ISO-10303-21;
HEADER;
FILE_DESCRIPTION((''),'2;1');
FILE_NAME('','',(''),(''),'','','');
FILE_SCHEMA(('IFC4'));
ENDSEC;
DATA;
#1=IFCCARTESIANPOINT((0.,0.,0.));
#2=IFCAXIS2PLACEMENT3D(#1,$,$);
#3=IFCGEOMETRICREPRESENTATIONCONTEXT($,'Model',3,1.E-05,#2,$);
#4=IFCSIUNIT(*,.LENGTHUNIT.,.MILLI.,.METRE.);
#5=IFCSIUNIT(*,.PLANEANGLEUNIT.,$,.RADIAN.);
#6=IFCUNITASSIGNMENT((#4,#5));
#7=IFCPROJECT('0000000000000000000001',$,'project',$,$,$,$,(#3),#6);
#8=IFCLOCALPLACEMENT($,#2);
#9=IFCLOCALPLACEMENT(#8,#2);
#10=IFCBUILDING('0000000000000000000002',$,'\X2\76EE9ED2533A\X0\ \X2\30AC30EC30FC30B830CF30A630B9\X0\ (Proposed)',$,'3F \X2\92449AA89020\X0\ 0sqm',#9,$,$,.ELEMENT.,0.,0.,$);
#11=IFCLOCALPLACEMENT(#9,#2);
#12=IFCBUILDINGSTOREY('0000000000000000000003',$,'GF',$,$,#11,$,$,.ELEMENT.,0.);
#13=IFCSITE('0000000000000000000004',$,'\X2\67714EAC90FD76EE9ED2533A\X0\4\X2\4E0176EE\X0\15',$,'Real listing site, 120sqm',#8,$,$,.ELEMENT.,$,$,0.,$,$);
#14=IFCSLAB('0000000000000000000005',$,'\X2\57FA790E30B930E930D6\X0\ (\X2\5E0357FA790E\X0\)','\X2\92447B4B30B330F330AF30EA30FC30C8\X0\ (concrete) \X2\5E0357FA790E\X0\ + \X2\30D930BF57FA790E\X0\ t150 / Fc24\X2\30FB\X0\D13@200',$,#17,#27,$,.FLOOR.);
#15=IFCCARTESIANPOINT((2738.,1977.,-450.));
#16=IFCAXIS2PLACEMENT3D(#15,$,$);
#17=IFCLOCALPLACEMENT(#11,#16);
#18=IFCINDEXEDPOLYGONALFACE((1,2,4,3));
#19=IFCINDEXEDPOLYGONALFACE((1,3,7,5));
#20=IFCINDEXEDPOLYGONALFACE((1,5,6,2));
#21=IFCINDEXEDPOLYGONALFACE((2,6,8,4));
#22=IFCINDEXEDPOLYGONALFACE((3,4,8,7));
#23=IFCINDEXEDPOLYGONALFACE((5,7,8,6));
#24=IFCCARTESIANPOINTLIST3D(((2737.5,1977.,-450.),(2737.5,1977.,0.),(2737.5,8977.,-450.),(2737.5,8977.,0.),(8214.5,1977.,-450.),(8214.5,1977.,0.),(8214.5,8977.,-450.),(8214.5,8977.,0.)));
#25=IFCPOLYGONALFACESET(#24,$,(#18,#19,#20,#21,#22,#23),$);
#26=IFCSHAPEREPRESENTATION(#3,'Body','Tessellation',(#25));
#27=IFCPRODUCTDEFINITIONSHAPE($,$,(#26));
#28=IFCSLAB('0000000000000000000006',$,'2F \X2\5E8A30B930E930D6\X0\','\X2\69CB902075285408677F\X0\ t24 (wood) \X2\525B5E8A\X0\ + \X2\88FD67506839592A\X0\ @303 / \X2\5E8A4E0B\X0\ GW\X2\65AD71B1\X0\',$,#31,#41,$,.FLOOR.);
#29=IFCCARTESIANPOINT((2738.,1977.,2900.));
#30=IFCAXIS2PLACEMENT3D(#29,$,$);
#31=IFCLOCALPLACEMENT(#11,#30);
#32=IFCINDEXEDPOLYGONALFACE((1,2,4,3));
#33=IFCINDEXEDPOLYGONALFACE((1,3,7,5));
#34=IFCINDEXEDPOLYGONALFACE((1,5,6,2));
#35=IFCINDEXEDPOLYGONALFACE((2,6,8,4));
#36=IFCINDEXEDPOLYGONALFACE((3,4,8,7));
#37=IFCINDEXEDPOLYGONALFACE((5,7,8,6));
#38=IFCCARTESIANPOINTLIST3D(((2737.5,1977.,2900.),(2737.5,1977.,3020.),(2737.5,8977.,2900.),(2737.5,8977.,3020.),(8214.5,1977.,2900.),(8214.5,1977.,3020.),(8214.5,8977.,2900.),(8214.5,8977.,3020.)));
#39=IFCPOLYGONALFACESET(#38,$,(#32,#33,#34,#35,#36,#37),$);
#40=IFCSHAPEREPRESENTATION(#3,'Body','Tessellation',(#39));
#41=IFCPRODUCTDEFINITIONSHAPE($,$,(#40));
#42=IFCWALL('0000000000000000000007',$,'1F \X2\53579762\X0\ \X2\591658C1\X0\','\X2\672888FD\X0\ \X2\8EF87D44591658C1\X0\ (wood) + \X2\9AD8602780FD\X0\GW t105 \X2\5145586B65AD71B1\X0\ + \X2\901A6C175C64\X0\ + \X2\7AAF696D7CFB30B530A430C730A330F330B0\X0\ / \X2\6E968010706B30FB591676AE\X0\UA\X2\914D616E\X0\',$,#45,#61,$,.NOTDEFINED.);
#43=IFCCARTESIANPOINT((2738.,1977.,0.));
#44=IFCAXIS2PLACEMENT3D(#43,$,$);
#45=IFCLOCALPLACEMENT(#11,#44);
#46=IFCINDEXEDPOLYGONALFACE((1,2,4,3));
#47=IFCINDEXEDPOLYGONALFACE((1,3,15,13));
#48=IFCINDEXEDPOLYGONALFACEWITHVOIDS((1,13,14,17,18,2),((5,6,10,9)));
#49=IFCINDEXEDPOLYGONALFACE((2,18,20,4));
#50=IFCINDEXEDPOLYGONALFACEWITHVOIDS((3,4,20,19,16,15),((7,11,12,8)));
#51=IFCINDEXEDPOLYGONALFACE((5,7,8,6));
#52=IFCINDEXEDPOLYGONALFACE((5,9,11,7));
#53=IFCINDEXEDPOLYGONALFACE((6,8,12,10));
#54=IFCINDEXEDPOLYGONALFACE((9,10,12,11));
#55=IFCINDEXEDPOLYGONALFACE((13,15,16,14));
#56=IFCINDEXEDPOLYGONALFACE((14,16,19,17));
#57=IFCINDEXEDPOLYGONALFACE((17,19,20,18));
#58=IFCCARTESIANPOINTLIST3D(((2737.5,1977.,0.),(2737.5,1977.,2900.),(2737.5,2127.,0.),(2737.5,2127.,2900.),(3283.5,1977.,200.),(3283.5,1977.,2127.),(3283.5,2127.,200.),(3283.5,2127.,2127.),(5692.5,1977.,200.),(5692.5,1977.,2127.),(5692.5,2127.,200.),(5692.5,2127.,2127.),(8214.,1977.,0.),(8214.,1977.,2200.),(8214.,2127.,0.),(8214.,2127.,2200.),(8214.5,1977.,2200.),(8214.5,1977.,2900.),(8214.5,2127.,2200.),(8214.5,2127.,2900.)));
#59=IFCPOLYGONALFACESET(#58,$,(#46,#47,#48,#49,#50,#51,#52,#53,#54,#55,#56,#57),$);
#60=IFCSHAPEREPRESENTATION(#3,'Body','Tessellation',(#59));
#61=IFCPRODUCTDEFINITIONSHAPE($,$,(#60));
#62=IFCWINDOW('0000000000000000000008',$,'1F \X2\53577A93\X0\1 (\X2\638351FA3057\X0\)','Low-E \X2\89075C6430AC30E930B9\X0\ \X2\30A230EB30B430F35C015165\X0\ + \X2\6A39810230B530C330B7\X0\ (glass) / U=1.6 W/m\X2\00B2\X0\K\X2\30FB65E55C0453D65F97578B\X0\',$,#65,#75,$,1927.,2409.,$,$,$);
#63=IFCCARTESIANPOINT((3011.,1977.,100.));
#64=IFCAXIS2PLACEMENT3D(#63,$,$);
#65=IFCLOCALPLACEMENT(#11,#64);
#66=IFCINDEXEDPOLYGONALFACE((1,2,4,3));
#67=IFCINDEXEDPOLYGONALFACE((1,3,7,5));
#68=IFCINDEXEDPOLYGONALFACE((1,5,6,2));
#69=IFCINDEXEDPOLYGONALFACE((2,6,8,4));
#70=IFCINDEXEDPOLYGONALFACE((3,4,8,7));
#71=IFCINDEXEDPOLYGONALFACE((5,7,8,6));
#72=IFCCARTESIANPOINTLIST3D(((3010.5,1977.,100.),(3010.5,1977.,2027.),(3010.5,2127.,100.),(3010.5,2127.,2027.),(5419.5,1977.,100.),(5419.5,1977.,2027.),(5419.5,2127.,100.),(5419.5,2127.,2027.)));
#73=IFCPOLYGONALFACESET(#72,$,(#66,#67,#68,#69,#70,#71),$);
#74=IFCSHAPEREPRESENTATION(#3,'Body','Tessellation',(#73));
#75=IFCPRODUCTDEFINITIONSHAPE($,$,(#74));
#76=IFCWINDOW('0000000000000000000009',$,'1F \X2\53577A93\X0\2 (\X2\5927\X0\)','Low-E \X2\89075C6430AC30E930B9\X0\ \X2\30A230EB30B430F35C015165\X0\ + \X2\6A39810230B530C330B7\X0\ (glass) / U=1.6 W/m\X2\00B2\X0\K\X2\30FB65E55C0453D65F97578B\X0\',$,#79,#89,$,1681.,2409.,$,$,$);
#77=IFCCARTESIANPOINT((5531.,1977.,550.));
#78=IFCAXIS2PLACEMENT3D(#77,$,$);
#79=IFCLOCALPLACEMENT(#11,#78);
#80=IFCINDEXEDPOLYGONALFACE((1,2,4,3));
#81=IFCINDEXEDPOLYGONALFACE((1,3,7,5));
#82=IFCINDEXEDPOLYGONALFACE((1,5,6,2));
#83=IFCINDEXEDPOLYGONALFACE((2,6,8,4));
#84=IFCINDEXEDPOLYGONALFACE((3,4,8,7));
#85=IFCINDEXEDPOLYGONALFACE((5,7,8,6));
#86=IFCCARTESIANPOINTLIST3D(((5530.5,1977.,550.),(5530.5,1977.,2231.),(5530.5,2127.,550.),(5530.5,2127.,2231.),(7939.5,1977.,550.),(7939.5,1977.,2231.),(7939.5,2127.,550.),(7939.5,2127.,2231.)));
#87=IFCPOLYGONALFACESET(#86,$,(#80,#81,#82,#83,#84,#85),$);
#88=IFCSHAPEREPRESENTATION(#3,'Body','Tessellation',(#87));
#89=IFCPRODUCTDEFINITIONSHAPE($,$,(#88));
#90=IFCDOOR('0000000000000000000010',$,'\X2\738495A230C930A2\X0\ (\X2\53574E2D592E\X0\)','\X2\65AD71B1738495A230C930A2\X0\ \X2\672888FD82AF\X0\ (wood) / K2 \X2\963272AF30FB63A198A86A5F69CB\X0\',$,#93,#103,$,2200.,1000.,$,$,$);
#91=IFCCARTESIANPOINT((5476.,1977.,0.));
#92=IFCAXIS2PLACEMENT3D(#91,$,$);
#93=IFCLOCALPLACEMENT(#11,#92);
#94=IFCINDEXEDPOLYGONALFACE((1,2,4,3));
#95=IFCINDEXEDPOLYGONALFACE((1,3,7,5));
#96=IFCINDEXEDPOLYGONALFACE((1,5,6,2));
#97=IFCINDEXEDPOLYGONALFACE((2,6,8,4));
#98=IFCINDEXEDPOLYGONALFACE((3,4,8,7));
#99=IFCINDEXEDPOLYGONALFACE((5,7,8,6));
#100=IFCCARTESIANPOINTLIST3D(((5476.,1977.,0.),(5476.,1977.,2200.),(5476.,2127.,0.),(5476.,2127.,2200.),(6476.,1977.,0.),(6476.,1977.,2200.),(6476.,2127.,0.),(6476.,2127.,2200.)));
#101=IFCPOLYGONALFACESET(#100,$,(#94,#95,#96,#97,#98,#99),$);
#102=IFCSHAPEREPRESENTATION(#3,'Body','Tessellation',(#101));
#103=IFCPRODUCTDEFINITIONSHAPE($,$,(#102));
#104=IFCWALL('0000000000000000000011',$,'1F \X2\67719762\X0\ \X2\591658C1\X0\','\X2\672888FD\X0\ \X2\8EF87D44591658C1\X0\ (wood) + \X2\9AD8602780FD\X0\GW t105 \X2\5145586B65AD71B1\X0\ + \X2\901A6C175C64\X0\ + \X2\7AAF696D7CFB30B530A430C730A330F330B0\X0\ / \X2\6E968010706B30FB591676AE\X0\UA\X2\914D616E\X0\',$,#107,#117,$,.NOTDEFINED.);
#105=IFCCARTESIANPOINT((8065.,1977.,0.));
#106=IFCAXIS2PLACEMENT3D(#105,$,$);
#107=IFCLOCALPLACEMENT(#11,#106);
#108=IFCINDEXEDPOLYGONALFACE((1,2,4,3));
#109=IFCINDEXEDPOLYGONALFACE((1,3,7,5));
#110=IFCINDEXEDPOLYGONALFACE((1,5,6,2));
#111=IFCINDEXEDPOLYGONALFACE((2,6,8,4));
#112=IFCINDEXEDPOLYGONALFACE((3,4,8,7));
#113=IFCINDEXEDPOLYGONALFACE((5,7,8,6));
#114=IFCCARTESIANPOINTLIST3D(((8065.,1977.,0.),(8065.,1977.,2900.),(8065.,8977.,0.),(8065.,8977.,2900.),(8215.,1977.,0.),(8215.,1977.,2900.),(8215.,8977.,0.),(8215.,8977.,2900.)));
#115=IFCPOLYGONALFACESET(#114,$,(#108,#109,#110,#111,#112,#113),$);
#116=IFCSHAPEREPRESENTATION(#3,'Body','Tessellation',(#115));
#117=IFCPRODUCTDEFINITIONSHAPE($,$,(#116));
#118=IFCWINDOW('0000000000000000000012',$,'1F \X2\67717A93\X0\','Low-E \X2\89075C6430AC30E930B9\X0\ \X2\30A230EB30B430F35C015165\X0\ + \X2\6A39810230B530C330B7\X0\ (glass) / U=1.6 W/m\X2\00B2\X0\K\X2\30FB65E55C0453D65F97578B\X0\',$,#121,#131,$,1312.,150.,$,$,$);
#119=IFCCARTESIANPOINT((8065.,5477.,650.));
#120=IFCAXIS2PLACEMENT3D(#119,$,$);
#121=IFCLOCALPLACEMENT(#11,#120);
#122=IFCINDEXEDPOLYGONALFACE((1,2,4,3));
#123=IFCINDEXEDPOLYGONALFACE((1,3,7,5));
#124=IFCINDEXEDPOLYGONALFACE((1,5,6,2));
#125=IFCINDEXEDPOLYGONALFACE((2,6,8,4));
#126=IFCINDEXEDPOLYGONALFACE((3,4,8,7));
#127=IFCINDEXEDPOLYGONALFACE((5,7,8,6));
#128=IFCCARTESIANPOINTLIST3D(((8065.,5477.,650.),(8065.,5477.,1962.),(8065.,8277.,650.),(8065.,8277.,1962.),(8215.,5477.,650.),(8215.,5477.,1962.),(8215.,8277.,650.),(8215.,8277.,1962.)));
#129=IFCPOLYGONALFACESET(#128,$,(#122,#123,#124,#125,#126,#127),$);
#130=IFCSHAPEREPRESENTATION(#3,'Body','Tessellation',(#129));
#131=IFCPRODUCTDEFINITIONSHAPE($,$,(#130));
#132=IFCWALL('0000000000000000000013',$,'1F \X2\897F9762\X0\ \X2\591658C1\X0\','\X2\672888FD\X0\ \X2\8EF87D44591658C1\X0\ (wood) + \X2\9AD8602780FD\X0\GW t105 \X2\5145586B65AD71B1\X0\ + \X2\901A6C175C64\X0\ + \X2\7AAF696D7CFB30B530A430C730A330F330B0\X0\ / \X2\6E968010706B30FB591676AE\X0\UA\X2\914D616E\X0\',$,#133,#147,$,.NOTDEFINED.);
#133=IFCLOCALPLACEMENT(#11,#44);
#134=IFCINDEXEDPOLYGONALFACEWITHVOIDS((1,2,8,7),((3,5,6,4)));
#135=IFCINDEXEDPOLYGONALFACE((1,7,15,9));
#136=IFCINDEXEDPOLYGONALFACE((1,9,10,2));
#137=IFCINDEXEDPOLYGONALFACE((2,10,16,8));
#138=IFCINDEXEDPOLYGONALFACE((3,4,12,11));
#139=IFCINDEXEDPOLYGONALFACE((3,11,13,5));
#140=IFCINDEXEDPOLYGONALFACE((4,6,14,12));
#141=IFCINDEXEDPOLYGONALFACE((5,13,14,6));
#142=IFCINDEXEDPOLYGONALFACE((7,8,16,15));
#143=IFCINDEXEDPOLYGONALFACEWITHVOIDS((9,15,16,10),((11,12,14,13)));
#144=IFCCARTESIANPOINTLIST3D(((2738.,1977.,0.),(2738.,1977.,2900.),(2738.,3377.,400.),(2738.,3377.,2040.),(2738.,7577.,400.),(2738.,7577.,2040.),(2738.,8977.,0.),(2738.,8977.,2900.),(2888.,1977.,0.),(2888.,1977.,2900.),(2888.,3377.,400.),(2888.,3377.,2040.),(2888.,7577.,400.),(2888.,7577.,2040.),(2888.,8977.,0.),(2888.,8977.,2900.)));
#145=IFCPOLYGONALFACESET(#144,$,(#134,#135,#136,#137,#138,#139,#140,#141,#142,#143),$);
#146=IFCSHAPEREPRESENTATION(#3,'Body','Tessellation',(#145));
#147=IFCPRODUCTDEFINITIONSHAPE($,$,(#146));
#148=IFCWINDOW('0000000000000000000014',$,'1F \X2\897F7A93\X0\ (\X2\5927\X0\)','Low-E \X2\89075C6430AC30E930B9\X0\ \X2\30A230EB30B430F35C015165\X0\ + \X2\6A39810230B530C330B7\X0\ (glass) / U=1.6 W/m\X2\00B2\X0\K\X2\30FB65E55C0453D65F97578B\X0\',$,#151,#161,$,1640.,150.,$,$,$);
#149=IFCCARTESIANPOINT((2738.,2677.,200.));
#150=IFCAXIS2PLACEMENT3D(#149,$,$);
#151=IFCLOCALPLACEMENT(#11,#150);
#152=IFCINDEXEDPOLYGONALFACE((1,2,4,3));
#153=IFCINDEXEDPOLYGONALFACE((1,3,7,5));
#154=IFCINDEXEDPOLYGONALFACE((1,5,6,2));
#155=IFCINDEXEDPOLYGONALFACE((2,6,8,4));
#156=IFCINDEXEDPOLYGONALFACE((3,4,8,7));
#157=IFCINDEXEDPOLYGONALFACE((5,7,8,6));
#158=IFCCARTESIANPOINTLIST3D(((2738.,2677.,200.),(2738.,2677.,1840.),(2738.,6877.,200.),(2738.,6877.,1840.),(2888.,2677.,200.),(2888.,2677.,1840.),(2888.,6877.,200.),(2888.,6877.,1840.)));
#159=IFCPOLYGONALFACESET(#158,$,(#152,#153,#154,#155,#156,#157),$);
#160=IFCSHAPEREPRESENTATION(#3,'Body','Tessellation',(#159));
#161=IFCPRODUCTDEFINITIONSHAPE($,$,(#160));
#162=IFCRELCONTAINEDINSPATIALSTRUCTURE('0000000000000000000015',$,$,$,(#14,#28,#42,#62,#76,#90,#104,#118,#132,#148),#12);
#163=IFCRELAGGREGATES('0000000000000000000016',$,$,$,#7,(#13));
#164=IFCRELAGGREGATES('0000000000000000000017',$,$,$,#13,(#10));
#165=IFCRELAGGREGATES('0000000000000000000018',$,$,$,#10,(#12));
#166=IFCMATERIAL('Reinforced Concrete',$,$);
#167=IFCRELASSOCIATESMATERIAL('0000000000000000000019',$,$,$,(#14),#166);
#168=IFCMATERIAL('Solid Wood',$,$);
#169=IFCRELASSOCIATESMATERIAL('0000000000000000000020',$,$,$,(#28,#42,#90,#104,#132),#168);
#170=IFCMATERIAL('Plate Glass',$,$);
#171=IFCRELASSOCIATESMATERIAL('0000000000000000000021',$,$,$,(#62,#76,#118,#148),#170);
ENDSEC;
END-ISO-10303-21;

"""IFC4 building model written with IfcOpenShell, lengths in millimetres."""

from ifc_helpers import new_model, si_unit, frame, frame_2d, origin, place, context, project, spatial, rectangle, extrude, material, element, fill, save


model = new_model("IFC4")

# Units and contexts
model_context = context("Model", 3, precision=1e-05, world=origin())
ifc_project = project(units=[si_unit("LENGTHUNIT", "METRE", prefix="MILLI"), si_unit("PLANEANGLEUNIT", "RADIAN")], contexts=[model_context])

# Site, building, storey
site_placement = place(None, origin())
site = spatial("IfcSite", under=ifc_project, at=site_placement, Name="東京都目黒区4丁目15", ObjectType="Real listing site, 120sqm", CompositionType="ELEMENT", RefElevation=0.0)
building_placement = place(site_placement, origin())
building = spatial("IfcBuilding", under=site, at=building_placement, Name="目黒区 ガレージハウス (Proposed)", ObjectType="3F 鉄骨造 0sqm", CompositionType="ELEMENT", ElevationOfRefHeight=0.0, ElevationOfTerrain=0.0)
storey_placement = place(building_placement, origin())
storey = spatial("IfcBuildingStorey", under=building, at=storey_placement, Name="GF", CompositionType="ELEMENT", Elevation=0.0)

# Slabs
ifc_material_1 = material(Name="Reinforced Concrete")
slab_1_placement = place(storey_placement, frame((2738.0, 1977.0, -450.0)))
element("IfcSlab", 1, at=slab_1_placement, inside=storey, material=ifc_material_1, Name="基礎スラブ (布基礎)", Description="鉄筋コンクリート (concrete) 布基礎 + ベタ基礎 t150 / Fc24・D13@200", PredefinedType="FLOOR", context=model_context, shape_type="SweptSolid", body=[
    extrude(rectangle(XDim=5477.0, YDim=7000.0, at=frame_2d((2738.0, 3500.0))), frame((2738.0, 1977.0, -450.0)), (0.0, 0.0, 1.0), 450.0),
])
ifc_material_2 = material(Name="Solid Wood")
slab_2_placement = place(storey_placement, frame((2738.0, 1977.0, 2900.0)))
element("IfcSlab", 2, at=slab_2_placement, inside=storey, material=ifc_material_2, Name="2F 床スラブ", Description="構造用合板 t24 (wood) 剛床 + 製材根太 @303 / 床下 GW断熱", PredefinedType="FLOOR", context=model_context, shape_type="SweptSolid", body=[
    extrude(rectangle(XDim=5477.0, YDim=7000.0, at=frame_2d((2738.0, 3500.0))), frame((2738.0, 1977.0, 2900.0)), (0.0, 0.0, 1.0), 120.0),
])

# Wall, openings, windows, door
wall_1_placement = place(storey_placement, frame((2738.0, 1977.0, 0.0)))
wall_1 = element("IfcWall", 3, at=wall_1_placement, inside=storey, material=ifc_material_2, Name="1F 南面 外壁", Description="木製 軸組外壁 (wood) + 高性能GW t105 充填断熱 + 通気層 + 窯業系サイディング / 準耐火・外皮UA配慮", PredefinedType="NOTDEFINED", context=model_context, shape_type="SweptSolid", body=[
    extrude(rectangle(XDim=5477.0, YDim=150.0, at=frame_2d((2738.0, 75.0))), frame((2738.0, 1977.0, 0.0)), (0.0, 0.0, 1.0), 2900.0),
])
opening_1_placement = place(storey_placement, frame((3011.0, 1977.0, 100.0)))
opening_1 = element("IfcOpeningElement", 4, at=opening_1_placement, cuts=wall_1, PredefinedType="NOTDEFINED", context=model_context, shape_type="SweptSolid", body=[
    extrude(rectangle(XDim=2409.0, YDim=150.0, at=frame_2d((1204.0, 75.0))), frame((3011.0, 1977.0, 100.0)), (0.0, 0.0, 1.0), 1927.0),
])
opening_2_placement = place(storey_placement, frame((5531.0, 1977.0, 550.0)))
opening_2 = element("IfcOpeningElement", 5, at=opening_2_placement, cuts=wall_1, PredefinedType="NOTDEFINED", context=model_context, shape_type="SweptSolid", body=[
    extrude(rectangle(XDim=2409.0, YDim=150.0, at=frame_2d((1204.0, 75.0))), frame((5531.0, 1977.0, 550.0)), (0.0, 0.0, 1.0), 1681.0),
])
opening_3_placement = place(storey_placement, frame((5476.0, 1977.0, 0.0)))
opening_3 = element("IfcOpeningElement", 6, at=opening_3_placement, cuts=wall_1, PredefinedType="NOTDEFINED", context=model_context, shape_type="SweptSolid", body=[
    extrude(rectangle(XDim=1000.0, YDim=150.0, at=frame_2d((500.0, 75.0))), frame((5476.0, 1977.0, 0.0)), (0.0, 0.0, 1.0), 2200.0),
])
ifc_material_3 = material(Name="Plate Glass")
window_1_placement = place(storey_placement, frame((3011.0, 1977.0, 100.0)))
window_1 = element("IfcWindow", 7, at=window_1_placement, inside=storey, material=ifc_material_3, Name="1F 南窓1 (掃出し)", Description="Low-E 複層ガラス アルゴン封入 + 樹脂サッシ (glass) / U=1.6 W/m²K・日射取得型", OverallHeight=1927.0, OverallWidth=2409.0, context=model_context, shape_type="SweptSolid", body=[
    extrude(rectangle(XDim=2409.0, YDim=150.0, at=frame_2d((1204.0, 75.0))), frame((3011.0, 1977.0, 100.0)), (0.0, 0.0, 1.0), 1927.0),
])
fill(opening_1, window_1)
window_2_placement = place(storey_placement, frame((5531.0, 1977.0, 550.0)))
window_2 = element("IfcWindow", 8, at=window_2_placement, inside=storey, material=ifc_material_3, Name="1F 南窓2 (大)", Description="Low-E 複層ガラス アルゴン封入 + 樹脂サッシ (glass) / U=1.6 W/m²K・日射取得型", OverallHeight=1681.0, OverallWidth=2409.0, context=model_context, shape_type="SweptSolid", body=[
    extrude(rectangle(XDim=2409.0, YDim=150.0, at=frame_2d((1204.0, 75.0))), frame((5531.0, 1977.0, 550.0)), (0.0, 0.0, 1.0), 1681.0),
])
fill(opening_2, window_2)
door_placement = place(storey_placement, frame((5476.0, 1977.0, 0.0)))
door = element("IfcDoor", 9, at=door_placement, inside=storey, material=ifc_material_2, Name="玄関ドア (南中央)", Description="断熱玄関ドア 木製芯 (wood) / K2 防犯・採風機構", OverallHeight=2200.0, OverallWidth=1000.0, context=model_context, shape_type="SweptSolid", body=[
    extrude(rectangle(XDim=1000.0, YDim=150.0, at=frame_2d((500.0, 75.0))), frame((5476.0, 1977.0, 0.0)), (0.0, 0.0, 1.0), 2200.0),
])
fill(opening_3, door)

# Walls, openings, windows
wall_2_placement = place(storey_placement, frame((8065.0, 1977.0, 0.0)))
wall_2 = element("IfcWall", 10, at=wall_2_placement, inside=storey, material=ifc_material_2, Name="1F 東面 外壁", Description="木製 軸組外壁 (wood) + 高性能GW t105 充填断熱 + 通気層 + 窯業系サイディング / 準耐火・外皮UA配慮", PredefinedType="NOTDEFINED", context=model_context, shape_type="SweptSolid", body=[
    extrude(rectangle(XDim=150.0, YDim=7000.0, at=frame_2d((75.0, 3500.0))), frame((8065.0, 1977.0, 0.0)), (0.0, 0.0, 1.0), 2900.0),
])
opening_4_placement = place(storey_placement, frame((8065.0, 5477.0, 650.0)))
opening_4 = element("IfcOpeningElement", 11, at=opening_4_placement, cuts=wall_2, PredefinedType="NOTDEFINED", context=model_context, shape_type="SweptSolid", body=[
    extrude(rectangle(XDim=150.0, YDim=2800.0, at=frame_2d((75.0, 1400.0))), frame((8065.0, 5477.0, 650.0)), (0.0, 0.0, 1.0), 1312.0),
])
window_3_placement = place(storey_placement, frame((8065.0, 5477.0, 650.0)))
window_3 = element("IfcWindow", 12, at=window_3_placement, inside=storey, material=ifc_material_3, Name="1F 東窓", Description="Low-E 複層ガラス アルゴン封入 + 樹脂サッシ (glass) / U=1.6 W/m²K・日射取得型", OverallHeight=1312.0, OverallWidth=150.0, context=model_context, shape_type="SweptSolid", body=[
    extrude(rectangle(XDim=150.0, YDim=2800.0, at=frame_2d((75.0, 1400.0))), frame((8065.0, 5477.0, 650.0)), (0.0, 0.0, 1.0), 1312.0),
])
fill(opening_4, window_3)
wall_3_placement = place(storey_placement, frame((2738.0, 1977.0, 0.0)))
wall_3 = element("IfcWall", 13, at=wall_3_placement, inside=storey, material=ifc_material_2, Name="1F 西面 外壁", Description="木製 軸組外壁 (wood) + 高性能GW t105 充填断熱 + 通気層 + 窯業系サイディング / 準耐火・外皮UA配慮", PredefinedType="NOTDEFINED", context=model_context, shape_type="SweptSolid", body=[
    extrude(rectangle(XDim=150.0, YDim=7000.0, at=frame_2d((75.0, 3500.0))), frame((2738.0, 1977.0, 0.0)), (0.0, 0.0, 1.0), 2900.0),
])
opening_5_placement = place(storey_placement, frame((2738.0, 2677.0, 200.0)))
opening_5 = element("IfcOpeningElement", 14, at=opening_5_placement, cuts=wall_3, PredefinedType="NOTDEFINED", context=model_context, shape_type="SweptSolid", body=[
    extrude(rectangle(XDim=150.0, YDim=4200.0, at=frame_2d((75.0, 2100.0))), frame((2738.0, 2677.0, 200.0)), (0.0, 0.0, 1.0), 1640.0),
])
window_4_placement = place(storey_placement, frame((2738.0, 2677.0, 200.0)))
window_4 = element("IfcWindow", 15, at=window_4_placement, inside=storey, material=ifc_material_3, Name="1F 西窓 (大)", Description="Low-E 複層ガラス アルゴン封入 + 樹脂サッシ (glass) / U=1.6 W/m²K・日射取得型", OverallHeight=1640.0, OverallWidth=150.0, context=model_context, shape_type="SweptSolid", body=[
    extrude(rectangle(XDim=150.0, YDim=4200.0, at=frame_2d((75.0, 2100.0))), frame((2738.0, 2677.0, 200.0)), (0.0, 0.0, 1.0), 1640.0),
])
fill(opening_5, window_4)

save(model, "model.ifc")
